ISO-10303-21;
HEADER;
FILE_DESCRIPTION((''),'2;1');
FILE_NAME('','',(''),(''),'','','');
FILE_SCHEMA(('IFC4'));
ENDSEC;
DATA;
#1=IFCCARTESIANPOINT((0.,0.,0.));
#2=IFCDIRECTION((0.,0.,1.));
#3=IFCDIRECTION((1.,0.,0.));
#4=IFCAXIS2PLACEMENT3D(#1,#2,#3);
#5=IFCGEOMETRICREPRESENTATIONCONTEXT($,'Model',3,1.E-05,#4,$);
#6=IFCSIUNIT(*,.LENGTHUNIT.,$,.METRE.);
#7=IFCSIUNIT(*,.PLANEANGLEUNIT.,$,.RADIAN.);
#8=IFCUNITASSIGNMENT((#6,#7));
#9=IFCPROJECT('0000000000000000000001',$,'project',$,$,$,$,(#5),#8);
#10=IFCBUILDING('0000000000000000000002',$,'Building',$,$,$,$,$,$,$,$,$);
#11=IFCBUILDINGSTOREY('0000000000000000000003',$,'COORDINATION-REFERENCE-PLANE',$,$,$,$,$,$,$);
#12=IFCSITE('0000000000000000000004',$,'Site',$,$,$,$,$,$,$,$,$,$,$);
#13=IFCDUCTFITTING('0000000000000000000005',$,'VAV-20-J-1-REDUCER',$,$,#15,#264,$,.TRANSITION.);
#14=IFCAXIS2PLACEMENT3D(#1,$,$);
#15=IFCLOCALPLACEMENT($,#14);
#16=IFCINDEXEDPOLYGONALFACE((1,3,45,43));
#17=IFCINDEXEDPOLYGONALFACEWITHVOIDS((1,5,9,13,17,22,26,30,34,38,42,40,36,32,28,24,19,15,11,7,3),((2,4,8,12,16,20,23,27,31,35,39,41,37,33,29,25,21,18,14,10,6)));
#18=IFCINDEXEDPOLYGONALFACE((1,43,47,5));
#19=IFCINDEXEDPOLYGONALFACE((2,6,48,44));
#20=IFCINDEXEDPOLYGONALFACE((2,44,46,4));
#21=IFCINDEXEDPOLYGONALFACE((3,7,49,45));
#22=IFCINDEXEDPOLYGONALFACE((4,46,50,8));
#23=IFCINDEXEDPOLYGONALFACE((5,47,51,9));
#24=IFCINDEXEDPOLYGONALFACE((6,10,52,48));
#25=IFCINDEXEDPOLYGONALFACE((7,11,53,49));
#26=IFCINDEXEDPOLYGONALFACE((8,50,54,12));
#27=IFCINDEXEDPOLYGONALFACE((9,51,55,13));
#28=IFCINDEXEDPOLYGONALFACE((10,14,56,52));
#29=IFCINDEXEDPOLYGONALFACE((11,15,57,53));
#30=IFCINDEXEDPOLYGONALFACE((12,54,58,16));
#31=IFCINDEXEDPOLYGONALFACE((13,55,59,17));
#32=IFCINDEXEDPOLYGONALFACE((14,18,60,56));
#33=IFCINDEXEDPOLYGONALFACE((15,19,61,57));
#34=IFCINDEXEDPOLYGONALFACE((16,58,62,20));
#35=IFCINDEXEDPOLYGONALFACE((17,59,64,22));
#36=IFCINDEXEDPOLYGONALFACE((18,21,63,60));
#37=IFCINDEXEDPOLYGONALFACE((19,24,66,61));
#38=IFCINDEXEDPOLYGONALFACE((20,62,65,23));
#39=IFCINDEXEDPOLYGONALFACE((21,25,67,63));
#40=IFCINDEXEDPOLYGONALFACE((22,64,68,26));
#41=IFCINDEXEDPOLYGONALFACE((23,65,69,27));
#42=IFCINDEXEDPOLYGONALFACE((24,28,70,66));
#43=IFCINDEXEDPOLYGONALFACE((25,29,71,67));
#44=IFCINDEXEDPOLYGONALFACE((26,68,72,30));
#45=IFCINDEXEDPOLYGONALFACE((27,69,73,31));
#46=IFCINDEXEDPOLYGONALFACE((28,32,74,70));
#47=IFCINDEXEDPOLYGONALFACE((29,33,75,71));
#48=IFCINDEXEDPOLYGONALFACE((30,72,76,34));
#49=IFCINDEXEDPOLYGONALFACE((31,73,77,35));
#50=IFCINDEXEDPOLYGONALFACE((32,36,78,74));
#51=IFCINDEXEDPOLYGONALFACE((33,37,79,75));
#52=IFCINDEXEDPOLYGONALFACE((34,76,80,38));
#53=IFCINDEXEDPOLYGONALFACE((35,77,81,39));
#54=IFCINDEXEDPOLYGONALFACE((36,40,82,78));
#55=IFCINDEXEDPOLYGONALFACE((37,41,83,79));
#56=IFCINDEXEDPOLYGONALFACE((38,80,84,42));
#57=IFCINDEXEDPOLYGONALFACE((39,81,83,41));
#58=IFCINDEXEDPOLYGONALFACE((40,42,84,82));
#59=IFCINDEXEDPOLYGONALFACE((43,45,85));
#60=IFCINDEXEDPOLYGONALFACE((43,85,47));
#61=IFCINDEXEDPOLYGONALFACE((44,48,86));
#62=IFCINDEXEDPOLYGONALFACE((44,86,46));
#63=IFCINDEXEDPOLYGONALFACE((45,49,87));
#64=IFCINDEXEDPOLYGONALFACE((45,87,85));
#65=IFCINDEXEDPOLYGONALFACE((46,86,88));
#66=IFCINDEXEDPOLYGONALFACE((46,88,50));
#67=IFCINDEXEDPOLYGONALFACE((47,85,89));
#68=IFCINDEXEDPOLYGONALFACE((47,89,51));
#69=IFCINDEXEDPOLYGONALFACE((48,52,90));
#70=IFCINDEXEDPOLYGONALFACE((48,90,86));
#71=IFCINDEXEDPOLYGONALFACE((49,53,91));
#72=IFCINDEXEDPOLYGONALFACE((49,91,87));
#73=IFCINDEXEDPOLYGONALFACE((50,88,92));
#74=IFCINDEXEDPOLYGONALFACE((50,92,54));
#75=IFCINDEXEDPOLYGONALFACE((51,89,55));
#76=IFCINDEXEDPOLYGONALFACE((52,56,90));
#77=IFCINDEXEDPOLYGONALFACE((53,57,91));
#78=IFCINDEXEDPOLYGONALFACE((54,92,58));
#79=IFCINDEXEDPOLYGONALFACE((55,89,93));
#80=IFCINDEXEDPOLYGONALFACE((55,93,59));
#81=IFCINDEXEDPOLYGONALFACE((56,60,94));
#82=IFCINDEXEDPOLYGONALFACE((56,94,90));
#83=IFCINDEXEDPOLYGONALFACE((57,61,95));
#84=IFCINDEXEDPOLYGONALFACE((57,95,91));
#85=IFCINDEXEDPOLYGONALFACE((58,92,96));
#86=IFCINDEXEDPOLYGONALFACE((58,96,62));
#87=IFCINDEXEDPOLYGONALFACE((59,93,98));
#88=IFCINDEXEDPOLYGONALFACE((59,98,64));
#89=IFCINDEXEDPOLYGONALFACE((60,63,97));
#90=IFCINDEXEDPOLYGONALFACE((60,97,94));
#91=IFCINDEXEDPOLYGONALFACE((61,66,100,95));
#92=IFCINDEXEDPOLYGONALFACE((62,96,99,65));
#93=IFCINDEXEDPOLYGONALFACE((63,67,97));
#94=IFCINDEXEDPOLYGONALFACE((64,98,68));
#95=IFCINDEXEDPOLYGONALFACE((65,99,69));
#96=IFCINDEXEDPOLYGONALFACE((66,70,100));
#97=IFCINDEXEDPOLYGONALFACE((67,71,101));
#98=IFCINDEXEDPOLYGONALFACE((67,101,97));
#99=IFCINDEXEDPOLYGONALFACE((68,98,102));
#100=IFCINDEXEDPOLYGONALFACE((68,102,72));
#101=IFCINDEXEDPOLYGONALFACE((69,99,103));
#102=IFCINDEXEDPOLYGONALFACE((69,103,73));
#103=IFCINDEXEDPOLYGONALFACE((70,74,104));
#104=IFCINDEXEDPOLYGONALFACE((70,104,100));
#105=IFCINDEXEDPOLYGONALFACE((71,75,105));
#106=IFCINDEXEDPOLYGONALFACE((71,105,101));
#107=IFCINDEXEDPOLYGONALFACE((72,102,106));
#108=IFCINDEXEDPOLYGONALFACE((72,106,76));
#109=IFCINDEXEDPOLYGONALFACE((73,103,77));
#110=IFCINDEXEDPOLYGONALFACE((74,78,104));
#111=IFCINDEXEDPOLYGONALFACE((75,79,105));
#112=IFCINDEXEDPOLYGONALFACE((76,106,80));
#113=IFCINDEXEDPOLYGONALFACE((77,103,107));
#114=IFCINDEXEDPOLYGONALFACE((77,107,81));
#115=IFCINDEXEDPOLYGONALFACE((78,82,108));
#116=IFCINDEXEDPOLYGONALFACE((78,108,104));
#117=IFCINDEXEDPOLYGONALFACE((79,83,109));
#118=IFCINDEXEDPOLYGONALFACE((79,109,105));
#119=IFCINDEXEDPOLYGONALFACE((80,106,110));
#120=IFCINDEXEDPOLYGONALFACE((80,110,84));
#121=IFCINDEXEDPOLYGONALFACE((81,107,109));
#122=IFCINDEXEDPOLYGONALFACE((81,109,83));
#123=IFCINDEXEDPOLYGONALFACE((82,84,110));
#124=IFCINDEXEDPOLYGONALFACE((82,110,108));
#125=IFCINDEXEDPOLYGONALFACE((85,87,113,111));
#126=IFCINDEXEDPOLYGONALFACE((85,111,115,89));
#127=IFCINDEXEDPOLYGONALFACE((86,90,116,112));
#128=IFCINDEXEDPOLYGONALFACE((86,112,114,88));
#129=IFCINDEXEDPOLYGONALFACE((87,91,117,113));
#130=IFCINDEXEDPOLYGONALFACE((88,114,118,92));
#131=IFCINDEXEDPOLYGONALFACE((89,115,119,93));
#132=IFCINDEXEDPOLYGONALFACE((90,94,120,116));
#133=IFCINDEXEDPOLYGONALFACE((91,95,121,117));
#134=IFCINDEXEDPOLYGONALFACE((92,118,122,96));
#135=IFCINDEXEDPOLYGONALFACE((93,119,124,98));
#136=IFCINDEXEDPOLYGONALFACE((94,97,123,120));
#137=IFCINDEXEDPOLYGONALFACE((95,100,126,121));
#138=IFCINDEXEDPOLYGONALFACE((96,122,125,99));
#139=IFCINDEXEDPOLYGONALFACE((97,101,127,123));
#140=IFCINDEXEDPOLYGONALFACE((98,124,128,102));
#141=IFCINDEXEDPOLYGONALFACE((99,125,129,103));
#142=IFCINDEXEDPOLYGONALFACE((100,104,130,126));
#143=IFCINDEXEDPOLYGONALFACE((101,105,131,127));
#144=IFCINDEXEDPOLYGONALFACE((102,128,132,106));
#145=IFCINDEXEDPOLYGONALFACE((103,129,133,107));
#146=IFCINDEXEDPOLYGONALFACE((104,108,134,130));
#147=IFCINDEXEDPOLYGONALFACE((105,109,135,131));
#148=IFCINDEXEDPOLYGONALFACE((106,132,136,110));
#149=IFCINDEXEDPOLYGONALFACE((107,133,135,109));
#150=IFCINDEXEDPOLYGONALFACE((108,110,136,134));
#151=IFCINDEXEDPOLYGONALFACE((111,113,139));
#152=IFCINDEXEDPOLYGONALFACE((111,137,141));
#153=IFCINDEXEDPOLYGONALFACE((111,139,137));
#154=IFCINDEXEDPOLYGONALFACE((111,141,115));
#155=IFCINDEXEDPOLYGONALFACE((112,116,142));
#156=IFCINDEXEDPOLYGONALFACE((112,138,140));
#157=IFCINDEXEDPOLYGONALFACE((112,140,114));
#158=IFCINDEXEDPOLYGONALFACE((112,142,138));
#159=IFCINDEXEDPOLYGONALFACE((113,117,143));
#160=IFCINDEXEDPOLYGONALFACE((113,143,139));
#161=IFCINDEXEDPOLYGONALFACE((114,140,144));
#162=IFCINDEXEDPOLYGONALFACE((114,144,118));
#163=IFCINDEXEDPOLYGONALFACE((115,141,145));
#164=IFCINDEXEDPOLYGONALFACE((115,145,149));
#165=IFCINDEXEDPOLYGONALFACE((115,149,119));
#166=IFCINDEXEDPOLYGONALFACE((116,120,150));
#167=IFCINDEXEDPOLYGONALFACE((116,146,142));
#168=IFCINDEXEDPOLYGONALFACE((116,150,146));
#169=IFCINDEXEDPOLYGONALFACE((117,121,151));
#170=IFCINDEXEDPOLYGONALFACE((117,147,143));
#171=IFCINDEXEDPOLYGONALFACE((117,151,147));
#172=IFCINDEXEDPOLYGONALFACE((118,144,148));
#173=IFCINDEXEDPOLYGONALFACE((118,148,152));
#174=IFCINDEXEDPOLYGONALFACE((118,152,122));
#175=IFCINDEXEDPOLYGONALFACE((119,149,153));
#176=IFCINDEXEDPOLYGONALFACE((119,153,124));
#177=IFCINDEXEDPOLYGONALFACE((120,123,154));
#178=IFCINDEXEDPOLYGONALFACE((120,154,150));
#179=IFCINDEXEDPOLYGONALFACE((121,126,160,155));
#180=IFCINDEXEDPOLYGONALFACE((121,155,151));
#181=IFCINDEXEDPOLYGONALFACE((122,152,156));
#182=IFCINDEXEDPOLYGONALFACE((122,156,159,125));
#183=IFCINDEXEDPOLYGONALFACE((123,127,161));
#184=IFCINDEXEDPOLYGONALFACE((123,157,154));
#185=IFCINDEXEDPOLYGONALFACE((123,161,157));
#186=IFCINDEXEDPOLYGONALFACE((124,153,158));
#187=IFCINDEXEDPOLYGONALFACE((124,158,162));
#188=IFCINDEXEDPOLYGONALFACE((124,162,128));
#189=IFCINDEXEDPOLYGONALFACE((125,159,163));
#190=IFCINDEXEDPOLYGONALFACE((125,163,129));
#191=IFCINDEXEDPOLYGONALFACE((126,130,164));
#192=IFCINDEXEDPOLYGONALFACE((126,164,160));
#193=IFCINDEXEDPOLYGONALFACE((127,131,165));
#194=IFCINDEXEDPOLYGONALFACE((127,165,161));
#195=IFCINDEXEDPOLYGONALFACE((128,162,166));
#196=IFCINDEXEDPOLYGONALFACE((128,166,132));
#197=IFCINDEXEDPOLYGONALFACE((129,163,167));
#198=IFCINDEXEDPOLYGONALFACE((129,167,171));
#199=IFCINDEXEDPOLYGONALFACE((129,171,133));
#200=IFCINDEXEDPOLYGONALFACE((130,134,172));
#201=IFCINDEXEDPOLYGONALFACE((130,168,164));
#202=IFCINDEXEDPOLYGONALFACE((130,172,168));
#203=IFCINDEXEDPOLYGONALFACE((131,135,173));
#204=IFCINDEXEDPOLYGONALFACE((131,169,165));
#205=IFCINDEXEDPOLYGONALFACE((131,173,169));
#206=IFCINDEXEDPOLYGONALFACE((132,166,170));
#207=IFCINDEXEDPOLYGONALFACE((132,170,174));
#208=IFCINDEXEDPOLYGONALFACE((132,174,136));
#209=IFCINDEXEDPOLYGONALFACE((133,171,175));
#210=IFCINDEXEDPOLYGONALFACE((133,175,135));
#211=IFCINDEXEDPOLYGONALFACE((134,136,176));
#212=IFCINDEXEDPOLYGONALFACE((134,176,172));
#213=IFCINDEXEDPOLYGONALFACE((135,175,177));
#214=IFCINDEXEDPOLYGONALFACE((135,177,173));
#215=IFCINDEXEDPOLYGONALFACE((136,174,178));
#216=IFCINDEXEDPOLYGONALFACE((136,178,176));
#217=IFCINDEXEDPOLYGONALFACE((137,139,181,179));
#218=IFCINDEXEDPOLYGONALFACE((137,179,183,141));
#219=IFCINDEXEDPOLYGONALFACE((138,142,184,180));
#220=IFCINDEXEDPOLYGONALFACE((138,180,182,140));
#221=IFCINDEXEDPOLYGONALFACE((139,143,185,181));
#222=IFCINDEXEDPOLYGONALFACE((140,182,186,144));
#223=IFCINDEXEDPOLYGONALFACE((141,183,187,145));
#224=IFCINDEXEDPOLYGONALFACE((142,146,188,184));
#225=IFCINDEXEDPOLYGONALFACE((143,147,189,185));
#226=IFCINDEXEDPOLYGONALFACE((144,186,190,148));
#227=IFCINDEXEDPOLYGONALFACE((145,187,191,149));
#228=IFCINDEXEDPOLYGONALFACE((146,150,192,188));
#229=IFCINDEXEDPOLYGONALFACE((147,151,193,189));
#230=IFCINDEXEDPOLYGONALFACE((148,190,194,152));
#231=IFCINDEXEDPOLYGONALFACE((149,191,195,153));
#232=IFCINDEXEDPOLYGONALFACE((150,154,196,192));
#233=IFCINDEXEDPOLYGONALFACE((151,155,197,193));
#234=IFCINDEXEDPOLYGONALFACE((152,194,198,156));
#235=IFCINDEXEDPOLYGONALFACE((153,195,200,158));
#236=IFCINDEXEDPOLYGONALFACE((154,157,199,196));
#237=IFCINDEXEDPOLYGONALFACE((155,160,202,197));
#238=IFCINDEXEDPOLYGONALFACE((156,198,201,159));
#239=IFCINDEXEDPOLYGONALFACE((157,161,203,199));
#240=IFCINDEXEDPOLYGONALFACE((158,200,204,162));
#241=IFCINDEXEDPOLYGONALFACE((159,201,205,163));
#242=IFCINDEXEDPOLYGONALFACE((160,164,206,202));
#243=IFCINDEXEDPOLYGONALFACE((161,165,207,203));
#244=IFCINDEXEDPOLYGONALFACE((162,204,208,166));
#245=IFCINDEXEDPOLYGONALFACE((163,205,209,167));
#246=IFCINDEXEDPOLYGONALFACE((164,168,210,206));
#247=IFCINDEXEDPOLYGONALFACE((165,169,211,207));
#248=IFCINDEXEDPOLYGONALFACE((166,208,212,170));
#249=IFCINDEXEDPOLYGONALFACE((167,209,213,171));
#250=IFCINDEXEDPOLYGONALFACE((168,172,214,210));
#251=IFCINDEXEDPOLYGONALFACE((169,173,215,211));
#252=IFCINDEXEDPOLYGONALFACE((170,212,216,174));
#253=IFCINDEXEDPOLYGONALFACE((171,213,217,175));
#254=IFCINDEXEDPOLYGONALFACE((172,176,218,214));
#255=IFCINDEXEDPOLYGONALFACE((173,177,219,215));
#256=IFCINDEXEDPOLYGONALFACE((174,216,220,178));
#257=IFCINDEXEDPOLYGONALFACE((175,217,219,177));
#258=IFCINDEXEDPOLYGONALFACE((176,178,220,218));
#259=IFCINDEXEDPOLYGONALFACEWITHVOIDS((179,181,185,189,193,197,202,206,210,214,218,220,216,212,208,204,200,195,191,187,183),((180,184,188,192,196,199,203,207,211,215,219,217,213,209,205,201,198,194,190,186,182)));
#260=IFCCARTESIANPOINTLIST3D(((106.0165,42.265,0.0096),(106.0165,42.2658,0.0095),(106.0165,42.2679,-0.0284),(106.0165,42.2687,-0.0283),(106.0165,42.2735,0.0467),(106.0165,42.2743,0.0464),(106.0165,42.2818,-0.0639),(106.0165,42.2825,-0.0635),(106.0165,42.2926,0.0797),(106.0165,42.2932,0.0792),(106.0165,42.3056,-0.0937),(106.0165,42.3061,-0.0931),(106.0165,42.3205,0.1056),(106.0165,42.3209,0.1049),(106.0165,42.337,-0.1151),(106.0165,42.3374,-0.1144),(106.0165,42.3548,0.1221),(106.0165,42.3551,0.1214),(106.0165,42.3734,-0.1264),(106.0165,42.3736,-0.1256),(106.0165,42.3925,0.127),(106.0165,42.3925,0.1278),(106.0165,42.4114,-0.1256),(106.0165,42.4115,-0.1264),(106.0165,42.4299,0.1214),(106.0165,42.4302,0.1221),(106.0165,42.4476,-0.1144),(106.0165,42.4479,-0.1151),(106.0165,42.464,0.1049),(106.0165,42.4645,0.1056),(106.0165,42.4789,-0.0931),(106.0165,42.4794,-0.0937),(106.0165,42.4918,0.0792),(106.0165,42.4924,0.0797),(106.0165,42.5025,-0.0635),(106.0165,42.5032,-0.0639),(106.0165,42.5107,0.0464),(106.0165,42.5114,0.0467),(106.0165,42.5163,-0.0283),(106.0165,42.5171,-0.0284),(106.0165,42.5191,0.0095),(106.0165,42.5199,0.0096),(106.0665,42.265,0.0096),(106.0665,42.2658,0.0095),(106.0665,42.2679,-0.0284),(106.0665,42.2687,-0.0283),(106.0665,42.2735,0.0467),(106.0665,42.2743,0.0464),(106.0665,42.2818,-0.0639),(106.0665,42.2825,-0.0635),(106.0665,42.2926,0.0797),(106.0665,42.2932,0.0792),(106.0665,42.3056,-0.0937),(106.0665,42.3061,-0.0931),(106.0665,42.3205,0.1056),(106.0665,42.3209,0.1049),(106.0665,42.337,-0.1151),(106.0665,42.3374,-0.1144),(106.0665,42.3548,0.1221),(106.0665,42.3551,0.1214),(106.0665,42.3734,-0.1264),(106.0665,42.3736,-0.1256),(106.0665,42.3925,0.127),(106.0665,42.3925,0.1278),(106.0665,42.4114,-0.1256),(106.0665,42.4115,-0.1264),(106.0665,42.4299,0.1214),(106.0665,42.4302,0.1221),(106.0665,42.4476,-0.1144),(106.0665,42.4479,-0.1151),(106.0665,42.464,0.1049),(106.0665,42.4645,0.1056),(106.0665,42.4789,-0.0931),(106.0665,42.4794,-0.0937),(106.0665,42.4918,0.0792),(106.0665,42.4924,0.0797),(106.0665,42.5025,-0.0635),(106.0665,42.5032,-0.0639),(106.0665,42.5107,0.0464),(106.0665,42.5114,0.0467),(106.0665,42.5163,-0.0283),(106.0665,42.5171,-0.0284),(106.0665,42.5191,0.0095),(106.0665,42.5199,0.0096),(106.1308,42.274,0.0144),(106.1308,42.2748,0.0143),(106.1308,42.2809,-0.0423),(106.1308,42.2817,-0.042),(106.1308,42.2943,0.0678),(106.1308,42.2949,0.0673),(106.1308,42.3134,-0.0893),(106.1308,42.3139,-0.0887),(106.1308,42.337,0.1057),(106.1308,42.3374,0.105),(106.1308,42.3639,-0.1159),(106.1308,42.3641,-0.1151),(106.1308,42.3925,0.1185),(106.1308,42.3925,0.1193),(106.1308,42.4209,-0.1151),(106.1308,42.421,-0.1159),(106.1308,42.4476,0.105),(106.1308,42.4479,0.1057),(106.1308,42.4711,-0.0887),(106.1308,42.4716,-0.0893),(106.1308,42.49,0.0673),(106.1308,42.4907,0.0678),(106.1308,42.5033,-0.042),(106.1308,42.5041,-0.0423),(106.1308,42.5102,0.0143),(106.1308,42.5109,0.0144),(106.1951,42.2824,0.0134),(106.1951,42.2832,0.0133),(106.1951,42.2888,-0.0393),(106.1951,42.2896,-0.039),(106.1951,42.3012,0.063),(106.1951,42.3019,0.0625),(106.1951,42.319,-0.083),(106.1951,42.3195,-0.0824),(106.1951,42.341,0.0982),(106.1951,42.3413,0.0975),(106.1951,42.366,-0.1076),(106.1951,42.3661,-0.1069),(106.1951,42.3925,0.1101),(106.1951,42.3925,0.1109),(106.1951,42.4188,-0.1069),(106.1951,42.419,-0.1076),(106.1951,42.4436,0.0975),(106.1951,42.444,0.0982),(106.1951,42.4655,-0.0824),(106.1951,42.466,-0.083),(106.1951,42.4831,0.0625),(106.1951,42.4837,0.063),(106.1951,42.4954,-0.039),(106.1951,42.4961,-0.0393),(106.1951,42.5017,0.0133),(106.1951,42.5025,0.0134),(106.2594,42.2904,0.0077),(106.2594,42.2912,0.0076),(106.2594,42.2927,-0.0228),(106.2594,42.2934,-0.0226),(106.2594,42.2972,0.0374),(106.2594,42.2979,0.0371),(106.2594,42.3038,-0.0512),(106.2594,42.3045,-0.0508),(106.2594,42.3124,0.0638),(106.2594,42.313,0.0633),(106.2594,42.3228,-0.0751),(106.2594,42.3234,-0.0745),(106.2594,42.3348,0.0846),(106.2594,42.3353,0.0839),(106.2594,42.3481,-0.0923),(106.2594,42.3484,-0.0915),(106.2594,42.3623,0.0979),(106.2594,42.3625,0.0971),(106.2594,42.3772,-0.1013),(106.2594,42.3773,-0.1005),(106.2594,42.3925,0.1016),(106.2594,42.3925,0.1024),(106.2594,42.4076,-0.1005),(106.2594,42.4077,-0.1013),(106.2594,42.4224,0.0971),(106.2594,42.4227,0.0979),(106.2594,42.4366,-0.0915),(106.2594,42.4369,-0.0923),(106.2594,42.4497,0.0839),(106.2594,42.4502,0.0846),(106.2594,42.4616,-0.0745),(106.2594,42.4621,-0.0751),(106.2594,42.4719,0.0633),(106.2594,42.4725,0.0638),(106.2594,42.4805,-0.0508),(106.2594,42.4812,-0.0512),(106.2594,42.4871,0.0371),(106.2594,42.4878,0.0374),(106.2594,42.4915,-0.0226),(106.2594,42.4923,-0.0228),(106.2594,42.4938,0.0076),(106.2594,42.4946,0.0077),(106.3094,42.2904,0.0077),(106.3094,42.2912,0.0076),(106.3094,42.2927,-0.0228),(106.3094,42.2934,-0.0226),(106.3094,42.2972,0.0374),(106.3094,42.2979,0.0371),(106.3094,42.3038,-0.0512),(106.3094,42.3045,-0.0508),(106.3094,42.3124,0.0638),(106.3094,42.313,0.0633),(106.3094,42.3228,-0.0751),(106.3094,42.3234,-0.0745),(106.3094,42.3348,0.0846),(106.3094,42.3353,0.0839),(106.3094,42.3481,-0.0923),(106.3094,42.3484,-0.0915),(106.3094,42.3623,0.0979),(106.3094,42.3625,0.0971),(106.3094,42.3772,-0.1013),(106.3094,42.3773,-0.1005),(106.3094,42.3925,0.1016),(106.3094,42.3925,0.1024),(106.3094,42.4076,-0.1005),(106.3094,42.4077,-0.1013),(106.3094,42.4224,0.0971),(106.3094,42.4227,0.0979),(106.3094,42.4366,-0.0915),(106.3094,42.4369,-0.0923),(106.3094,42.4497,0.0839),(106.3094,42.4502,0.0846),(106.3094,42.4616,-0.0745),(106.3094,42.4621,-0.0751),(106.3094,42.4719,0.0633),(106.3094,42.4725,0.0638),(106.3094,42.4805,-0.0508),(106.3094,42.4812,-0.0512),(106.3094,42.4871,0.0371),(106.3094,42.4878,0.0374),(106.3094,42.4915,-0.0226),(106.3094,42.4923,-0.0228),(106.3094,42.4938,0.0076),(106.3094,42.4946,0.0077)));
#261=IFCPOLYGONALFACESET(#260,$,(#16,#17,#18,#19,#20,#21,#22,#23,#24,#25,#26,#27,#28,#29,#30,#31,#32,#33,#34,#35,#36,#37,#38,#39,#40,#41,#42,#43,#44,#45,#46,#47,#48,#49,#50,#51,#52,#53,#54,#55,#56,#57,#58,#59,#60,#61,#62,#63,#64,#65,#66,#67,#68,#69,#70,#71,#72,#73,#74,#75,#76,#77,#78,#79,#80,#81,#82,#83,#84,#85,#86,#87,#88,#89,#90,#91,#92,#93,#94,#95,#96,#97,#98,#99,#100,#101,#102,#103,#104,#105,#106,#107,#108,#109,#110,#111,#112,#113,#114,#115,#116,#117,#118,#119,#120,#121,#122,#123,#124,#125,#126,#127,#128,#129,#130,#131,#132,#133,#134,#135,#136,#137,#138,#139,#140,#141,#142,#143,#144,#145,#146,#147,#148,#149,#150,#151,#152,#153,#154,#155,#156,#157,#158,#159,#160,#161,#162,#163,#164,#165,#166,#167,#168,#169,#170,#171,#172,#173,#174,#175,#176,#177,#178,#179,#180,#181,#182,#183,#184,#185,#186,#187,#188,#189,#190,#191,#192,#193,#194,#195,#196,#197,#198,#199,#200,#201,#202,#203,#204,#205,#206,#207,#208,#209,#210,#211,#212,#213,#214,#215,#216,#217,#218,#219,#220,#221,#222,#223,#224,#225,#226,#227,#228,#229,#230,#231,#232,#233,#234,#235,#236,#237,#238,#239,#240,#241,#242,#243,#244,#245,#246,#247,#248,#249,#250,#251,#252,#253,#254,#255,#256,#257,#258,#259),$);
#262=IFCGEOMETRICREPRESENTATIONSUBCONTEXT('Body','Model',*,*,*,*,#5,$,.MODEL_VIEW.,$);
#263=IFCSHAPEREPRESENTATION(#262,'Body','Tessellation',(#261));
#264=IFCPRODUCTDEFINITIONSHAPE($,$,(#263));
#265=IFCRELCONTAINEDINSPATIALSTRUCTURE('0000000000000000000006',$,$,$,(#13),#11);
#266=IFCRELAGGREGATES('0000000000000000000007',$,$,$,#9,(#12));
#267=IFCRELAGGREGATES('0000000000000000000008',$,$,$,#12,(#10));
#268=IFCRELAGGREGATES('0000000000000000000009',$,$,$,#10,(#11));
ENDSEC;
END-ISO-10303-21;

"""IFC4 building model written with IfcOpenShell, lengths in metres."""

from ifc_helpers import new_model, entity, si_unit, frame, origin_with_axes, place, context, subcontext, project, spatial, element, save


model = new_model("IFC4")

# Units and contexts
model_context = context("Model", 3, precision=1e-05, world=origin_with_axes())
body_context_1 = subcontext(model_context, "Body", "Model", "MODEL_VIEW")
ifc_project = project(units=[si_unit("LENGTHUNIT", "METRE"), si_unit("PLANEANGLEUNIT", "RADIAN")], contexts=[model_context])

# Site, building, storey
site = spatial("IfcSite", under=ifc_project, Name="Site")
building = spatial("IfcBuilding", under=site, Name="Building")
storey = spatial("IfcBuildingStorey", under=building, Name="COORDINATION-REFERENCE-PLANE")

# Duct fitting
for number, where, z_axis, x_axis, name in (
    (1, (106.0165, 42.3925, 0.0), (0.0, 1.0, 0.0), (0.0, 0.0, 1.0), "VAV-20-J-1-REDUCER"),
):
    element("IfcDuctFitting", number, at=place(None, frame(where, z_axis=z_axis, x_axis=x_axis)), inside=storey, Name=name, PredefinedType="TRANSITION", context=body_context_1, shape_type="SweptSolid", body=[
        entity("IfcRevolvedAreaSolid", entity("IfcArbitraryClosedProfileDef", "AREA", None, entity("IfcPolyline", [entity("IfcCartesianPoint", [0.1278, 0.0]), entity("IfcCartesianPoint", [0.1278, 0.05]), entity("IfcCartesianPoint", [0.1024, 0.2429]), entity("IfcCartesianPoint", [0.1024, 0.2929]), entity("IfcCartesianPoint", [0.1016, 0.2929]), entity("IfcCartesianPoint", [0.1016, 0.2429]), entity("IfcCartesianPoint", [0.127, 0.05]), entity("IfcCartesianPoint", [0.127, 0.0]), entity("IfcCartesianPoint", [0.1278, 0.0])])), entity("IfcAxis2Placement3D", entity("IfcCartesianPoint", [0.0, 0.0, 0.0])), entity("IfcAxis1Placement", entity("IfcCartesianPoint", [0.0, 0.0, 0.0]), entity("IfcDirection", [0.0, 1.0, 0.0])), 6.283185),
    ])

save(model, "model.ifc")
